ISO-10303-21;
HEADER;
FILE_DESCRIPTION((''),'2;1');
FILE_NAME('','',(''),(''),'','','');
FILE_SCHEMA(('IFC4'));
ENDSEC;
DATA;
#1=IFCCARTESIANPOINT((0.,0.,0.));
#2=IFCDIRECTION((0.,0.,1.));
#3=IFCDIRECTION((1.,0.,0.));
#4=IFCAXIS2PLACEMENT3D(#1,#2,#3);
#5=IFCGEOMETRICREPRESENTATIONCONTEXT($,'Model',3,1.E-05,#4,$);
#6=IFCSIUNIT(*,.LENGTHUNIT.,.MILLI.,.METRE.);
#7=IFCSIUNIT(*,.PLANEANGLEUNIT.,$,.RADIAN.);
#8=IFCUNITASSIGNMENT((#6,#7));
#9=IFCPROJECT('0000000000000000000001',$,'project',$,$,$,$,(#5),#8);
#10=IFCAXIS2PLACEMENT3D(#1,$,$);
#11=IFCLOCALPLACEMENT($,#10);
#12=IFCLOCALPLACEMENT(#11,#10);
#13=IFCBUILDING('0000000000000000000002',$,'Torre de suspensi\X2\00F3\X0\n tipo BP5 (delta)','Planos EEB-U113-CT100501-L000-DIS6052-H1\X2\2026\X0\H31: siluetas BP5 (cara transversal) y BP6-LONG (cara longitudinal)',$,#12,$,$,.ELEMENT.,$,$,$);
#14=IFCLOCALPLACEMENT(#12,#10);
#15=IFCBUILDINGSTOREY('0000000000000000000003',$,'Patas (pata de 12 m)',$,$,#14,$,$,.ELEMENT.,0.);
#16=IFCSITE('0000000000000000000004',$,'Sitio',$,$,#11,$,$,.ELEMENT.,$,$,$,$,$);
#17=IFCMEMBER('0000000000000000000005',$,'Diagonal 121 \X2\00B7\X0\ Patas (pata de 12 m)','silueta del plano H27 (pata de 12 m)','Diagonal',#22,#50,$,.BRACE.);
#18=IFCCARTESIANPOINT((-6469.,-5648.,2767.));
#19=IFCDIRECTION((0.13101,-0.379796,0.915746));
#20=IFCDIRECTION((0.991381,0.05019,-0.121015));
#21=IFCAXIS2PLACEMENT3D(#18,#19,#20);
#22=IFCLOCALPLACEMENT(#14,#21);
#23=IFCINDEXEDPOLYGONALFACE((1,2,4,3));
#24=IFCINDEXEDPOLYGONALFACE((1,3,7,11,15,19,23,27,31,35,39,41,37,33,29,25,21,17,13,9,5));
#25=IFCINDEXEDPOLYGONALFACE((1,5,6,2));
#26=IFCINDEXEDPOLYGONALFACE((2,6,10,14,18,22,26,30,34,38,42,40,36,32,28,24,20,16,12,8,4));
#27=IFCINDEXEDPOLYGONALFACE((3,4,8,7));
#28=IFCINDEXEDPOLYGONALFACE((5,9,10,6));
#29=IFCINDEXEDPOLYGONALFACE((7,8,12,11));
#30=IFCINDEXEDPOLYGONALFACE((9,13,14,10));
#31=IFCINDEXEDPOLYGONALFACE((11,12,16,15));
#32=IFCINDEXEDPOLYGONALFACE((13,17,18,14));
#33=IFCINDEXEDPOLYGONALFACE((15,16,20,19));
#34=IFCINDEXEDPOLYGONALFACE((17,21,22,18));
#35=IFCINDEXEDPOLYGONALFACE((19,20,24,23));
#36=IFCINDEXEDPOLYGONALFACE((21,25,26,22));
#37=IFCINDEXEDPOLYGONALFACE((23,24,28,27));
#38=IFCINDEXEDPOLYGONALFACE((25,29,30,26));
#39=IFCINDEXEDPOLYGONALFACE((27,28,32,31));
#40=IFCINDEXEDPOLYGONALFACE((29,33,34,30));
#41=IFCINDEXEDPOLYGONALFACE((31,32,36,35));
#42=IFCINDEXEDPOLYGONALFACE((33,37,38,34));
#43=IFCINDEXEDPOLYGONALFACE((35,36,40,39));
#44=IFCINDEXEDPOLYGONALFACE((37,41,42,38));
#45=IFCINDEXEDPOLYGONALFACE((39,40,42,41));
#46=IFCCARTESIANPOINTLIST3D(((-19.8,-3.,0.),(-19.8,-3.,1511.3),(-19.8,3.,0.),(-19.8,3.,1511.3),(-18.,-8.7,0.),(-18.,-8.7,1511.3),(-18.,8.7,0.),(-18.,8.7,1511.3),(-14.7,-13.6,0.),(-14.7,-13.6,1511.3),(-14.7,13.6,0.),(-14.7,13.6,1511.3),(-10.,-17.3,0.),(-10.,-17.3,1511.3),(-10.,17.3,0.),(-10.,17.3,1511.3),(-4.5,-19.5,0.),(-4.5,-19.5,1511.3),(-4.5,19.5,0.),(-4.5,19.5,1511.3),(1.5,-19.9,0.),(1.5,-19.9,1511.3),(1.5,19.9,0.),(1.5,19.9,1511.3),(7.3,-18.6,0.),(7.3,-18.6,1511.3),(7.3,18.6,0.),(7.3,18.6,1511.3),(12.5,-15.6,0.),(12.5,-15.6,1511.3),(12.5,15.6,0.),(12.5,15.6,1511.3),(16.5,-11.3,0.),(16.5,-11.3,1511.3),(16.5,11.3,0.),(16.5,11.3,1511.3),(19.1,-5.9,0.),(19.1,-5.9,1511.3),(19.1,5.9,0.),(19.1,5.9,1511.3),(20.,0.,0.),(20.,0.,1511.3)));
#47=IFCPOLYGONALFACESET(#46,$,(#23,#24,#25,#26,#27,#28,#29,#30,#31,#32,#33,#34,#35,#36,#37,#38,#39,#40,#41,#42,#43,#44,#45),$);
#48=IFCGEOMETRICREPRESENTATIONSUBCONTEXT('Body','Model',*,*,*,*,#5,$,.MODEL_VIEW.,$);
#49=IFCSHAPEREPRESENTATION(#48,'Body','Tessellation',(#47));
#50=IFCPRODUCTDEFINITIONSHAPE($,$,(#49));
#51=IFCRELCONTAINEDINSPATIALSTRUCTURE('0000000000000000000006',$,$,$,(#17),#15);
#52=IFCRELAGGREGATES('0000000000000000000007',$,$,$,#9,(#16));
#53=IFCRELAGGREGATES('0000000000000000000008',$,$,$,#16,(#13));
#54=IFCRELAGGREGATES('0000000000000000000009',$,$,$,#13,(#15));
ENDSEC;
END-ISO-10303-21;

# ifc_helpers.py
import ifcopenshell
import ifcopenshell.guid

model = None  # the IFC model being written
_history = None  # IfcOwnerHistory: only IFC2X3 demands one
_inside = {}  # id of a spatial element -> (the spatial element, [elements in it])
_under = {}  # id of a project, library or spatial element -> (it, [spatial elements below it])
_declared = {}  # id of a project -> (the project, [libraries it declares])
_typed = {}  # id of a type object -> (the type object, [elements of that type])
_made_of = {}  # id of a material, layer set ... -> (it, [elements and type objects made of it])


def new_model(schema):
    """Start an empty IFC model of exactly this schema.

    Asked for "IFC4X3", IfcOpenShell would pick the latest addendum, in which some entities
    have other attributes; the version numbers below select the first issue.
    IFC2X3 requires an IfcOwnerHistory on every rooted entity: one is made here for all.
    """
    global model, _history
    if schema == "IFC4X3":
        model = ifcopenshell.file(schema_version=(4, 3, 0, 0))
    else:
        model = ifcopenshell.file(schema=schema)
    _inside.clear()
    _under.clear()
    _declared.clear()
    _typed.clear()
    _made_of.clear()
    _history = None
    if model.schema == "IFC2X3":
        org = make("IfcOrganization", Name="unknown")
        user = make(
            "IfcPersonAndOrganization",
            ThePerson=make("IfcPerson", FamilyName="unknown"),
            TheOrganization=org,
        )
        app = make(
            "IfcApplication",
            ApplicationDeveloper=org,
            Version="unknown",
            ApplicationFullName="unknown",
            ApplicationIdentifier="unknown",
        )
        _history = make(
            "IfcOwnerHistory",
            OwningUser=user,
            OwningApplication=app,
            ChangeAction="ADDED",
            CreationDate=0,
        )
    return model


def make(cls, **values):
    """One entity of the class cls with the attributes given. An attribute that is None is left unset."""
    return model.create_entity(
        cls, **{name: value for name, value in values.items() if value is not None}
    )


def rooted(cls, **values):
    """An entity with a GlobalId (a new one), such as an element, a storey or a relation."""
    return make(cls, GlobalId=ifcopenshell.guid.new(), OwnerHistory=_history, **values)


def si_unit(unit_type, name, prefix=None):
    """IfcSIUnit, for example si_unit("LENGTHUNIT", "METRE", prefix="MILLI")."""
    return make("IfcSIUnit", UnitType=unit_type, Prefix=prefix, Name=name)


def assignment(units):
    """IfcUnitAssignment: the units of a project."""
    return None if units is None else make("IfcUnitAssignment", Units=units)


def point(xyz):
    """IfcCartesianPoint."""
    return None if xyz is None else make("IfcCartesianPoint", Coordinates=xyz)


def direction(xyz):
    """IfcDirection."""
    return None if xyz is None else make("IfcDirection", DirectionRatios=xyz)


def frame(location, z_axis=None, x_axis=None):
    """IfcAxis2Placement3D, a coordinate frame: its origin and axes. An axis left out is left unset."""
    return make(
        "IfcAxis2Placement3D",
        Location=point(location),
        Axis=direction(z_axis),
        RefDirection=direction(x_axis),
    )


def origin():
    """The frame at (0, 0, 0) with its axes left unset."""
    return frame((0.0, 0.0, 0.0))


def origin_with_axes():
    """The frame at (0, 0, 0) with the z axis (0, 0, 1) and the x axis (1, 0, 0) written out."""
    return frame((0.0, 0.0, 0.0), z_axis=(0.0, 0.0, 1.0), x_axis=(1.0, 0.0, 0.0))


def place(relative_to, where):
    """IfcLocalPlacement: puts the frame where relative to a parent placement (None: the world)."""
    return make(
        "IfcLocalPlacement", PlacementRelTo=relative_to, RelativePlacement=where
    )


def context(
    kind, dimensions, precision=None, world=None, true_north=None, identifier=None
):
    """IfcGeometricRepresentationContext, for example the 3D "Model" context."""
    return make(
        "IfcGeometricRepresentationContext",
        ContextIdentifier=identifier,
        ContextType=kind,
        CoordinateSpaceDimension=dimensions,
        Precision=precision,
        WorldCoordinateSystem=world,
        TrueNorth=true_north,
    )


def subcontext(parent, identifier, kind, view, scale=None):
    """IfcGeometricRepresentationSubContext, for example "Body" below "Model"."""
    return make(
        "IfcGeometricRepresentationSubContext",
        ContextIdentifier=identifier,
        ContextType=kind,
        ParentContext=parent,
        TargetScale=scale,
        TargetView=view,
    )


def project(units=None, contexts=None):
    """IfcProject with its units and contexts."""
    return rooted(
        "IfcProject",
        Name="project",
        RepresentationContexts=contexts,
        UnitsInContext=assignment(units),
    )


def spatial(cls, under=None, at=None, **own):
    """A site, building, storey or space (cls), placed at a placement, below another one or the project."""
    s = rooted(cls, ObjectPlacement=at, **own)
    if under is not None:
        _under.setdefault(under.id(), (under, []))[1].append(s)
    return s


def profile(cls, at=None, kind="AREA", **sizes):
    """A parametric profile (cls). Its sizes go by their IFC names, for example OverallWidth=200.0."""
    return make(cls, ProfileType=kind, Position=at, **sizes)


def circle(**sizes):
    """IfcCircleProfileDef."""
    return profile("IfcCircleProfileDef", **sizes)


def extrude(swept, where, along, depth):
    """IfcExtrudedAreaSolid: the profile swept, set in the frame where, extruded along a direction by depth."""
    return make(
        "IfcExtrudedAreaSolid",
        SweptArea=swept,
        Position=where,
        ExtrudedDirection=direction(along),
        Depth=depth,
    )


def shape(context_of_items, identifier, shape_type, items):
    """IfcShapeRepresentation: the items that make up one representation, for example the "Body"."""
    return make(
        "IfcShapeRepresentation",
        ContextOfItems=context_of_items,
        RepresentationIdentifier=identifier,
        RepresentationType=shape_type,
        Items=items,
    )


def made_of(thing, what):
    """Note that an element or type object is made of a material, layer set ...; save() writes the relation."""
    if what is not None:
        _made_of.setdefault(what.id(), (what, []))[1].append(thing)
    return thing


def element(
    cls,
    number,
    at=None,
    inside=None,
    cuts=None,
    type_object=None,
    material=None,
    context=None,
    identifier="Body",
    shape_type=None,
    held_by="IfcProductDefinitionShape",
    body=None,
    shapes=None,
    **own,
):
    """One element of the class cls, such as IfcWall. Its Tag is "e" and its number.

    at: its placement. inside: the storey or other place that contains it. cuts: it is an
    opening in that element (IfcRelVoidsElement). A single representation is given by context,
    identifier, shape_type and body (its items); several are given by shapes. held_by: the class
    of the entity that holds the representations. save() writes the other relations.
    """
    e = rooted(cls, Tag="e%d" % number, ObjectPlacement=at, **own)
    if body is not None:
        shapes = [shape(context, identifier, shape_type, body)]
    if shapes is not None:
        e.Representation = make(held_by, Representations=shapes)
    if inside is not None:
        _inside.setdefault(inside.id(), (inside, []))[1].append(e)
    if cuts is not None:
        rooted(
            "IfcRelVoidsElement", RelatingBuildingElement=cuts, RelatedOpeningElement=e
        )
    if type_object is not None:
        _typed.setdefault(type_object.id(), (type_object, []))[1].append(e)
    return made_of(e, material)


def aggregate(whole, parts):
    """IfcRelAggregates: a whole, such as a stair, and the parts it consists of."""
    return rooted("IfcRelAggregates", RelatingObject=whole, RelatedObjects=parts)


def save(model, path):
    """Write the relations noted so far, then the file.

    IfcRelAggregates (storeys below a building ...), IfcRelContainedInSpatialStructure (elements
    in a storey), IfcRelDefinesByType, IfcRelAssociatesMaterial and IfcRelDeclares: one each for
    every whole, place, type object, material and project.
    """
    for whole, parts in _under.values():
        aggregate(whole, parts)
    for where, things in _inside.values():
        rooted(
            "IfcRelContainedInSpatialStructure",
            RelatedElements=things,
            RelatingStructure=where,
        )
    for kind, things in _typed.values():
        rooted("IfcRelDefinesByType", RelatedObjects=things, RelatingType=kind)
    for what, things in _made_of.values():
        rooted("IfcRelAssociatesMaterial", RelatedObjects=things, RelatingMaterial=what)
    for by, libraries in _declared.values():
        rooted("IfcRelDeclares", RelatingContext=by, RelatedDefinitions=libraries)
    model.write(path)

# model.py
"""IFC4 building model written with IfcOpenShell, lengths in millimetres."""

from ifc_helpers import new_model, si_unit, frame, origin, origin_with_axes, place, context, subcontext, project, spatial, circle, extrude, element, save


model = new_model("IFC4")

# Units and contexts
model_context = context("Model", 3, precision=1e-05, world=origin_with_axes())
body_context = subcontext(model_context, "Body", "Model", "MODEL_VIEW")
ifc_project = project(units=[si_unit("LENGTHUNIT", "METRE", prefix="MILLI"), si_unit("PLANEANGLEUNIT", "RADIAN")], contexts=[model_context])

# Site, building, storey
site_placement = place(None, origin())
site = spatial("IfcSite", under=ifc_project, at=site_placement, Name="Sitio", CompositionType="ELEMENT")
building_placement = place(site_placement, origin())
building = spatial("IfcBuilding", under=site, at=building_placement, Name="Torre de suspensión tipo BP5 (delta)", Description="Planos EEB-U113-CT100501-L000-DIS6052-H1…H31: siluetas BP5 (cara transversal) y BP6-LONG (cara longitudinal)", CompositionType="ELEMENT")
storey_placement = place(building_placement, origin())
storey = spatial("IfcBuildingStorey", under=building, at=storey_placement, Name="Patas (pata de 12 m)", CompositionType="ELEMENT", Elevation=0.0)

# Member
member_1_placement = place(storey_placement, frame((-6469.0, -5648.0, 2767.0), z_axis=(0.13101, -0.379796, 0.915746), x_axis=(0.991381, 0.05019, -0.121015)))
element("IfcMember", 1, at=member_1_placement, inside=storey, Name="Diagonal 121 · Patas (pata de 12 m)", Description="silueta del plano H27 (pata de 12 m)", ObjectType="Diagonal", PredefinedType="BRACE", context=body_context, shape_type="SweptSolid", body=[
    extrude(circle(Radius=20.0), None, (0.0, 0.0, 1.0), 1511.3),
])

save(model, "model.ifc")
